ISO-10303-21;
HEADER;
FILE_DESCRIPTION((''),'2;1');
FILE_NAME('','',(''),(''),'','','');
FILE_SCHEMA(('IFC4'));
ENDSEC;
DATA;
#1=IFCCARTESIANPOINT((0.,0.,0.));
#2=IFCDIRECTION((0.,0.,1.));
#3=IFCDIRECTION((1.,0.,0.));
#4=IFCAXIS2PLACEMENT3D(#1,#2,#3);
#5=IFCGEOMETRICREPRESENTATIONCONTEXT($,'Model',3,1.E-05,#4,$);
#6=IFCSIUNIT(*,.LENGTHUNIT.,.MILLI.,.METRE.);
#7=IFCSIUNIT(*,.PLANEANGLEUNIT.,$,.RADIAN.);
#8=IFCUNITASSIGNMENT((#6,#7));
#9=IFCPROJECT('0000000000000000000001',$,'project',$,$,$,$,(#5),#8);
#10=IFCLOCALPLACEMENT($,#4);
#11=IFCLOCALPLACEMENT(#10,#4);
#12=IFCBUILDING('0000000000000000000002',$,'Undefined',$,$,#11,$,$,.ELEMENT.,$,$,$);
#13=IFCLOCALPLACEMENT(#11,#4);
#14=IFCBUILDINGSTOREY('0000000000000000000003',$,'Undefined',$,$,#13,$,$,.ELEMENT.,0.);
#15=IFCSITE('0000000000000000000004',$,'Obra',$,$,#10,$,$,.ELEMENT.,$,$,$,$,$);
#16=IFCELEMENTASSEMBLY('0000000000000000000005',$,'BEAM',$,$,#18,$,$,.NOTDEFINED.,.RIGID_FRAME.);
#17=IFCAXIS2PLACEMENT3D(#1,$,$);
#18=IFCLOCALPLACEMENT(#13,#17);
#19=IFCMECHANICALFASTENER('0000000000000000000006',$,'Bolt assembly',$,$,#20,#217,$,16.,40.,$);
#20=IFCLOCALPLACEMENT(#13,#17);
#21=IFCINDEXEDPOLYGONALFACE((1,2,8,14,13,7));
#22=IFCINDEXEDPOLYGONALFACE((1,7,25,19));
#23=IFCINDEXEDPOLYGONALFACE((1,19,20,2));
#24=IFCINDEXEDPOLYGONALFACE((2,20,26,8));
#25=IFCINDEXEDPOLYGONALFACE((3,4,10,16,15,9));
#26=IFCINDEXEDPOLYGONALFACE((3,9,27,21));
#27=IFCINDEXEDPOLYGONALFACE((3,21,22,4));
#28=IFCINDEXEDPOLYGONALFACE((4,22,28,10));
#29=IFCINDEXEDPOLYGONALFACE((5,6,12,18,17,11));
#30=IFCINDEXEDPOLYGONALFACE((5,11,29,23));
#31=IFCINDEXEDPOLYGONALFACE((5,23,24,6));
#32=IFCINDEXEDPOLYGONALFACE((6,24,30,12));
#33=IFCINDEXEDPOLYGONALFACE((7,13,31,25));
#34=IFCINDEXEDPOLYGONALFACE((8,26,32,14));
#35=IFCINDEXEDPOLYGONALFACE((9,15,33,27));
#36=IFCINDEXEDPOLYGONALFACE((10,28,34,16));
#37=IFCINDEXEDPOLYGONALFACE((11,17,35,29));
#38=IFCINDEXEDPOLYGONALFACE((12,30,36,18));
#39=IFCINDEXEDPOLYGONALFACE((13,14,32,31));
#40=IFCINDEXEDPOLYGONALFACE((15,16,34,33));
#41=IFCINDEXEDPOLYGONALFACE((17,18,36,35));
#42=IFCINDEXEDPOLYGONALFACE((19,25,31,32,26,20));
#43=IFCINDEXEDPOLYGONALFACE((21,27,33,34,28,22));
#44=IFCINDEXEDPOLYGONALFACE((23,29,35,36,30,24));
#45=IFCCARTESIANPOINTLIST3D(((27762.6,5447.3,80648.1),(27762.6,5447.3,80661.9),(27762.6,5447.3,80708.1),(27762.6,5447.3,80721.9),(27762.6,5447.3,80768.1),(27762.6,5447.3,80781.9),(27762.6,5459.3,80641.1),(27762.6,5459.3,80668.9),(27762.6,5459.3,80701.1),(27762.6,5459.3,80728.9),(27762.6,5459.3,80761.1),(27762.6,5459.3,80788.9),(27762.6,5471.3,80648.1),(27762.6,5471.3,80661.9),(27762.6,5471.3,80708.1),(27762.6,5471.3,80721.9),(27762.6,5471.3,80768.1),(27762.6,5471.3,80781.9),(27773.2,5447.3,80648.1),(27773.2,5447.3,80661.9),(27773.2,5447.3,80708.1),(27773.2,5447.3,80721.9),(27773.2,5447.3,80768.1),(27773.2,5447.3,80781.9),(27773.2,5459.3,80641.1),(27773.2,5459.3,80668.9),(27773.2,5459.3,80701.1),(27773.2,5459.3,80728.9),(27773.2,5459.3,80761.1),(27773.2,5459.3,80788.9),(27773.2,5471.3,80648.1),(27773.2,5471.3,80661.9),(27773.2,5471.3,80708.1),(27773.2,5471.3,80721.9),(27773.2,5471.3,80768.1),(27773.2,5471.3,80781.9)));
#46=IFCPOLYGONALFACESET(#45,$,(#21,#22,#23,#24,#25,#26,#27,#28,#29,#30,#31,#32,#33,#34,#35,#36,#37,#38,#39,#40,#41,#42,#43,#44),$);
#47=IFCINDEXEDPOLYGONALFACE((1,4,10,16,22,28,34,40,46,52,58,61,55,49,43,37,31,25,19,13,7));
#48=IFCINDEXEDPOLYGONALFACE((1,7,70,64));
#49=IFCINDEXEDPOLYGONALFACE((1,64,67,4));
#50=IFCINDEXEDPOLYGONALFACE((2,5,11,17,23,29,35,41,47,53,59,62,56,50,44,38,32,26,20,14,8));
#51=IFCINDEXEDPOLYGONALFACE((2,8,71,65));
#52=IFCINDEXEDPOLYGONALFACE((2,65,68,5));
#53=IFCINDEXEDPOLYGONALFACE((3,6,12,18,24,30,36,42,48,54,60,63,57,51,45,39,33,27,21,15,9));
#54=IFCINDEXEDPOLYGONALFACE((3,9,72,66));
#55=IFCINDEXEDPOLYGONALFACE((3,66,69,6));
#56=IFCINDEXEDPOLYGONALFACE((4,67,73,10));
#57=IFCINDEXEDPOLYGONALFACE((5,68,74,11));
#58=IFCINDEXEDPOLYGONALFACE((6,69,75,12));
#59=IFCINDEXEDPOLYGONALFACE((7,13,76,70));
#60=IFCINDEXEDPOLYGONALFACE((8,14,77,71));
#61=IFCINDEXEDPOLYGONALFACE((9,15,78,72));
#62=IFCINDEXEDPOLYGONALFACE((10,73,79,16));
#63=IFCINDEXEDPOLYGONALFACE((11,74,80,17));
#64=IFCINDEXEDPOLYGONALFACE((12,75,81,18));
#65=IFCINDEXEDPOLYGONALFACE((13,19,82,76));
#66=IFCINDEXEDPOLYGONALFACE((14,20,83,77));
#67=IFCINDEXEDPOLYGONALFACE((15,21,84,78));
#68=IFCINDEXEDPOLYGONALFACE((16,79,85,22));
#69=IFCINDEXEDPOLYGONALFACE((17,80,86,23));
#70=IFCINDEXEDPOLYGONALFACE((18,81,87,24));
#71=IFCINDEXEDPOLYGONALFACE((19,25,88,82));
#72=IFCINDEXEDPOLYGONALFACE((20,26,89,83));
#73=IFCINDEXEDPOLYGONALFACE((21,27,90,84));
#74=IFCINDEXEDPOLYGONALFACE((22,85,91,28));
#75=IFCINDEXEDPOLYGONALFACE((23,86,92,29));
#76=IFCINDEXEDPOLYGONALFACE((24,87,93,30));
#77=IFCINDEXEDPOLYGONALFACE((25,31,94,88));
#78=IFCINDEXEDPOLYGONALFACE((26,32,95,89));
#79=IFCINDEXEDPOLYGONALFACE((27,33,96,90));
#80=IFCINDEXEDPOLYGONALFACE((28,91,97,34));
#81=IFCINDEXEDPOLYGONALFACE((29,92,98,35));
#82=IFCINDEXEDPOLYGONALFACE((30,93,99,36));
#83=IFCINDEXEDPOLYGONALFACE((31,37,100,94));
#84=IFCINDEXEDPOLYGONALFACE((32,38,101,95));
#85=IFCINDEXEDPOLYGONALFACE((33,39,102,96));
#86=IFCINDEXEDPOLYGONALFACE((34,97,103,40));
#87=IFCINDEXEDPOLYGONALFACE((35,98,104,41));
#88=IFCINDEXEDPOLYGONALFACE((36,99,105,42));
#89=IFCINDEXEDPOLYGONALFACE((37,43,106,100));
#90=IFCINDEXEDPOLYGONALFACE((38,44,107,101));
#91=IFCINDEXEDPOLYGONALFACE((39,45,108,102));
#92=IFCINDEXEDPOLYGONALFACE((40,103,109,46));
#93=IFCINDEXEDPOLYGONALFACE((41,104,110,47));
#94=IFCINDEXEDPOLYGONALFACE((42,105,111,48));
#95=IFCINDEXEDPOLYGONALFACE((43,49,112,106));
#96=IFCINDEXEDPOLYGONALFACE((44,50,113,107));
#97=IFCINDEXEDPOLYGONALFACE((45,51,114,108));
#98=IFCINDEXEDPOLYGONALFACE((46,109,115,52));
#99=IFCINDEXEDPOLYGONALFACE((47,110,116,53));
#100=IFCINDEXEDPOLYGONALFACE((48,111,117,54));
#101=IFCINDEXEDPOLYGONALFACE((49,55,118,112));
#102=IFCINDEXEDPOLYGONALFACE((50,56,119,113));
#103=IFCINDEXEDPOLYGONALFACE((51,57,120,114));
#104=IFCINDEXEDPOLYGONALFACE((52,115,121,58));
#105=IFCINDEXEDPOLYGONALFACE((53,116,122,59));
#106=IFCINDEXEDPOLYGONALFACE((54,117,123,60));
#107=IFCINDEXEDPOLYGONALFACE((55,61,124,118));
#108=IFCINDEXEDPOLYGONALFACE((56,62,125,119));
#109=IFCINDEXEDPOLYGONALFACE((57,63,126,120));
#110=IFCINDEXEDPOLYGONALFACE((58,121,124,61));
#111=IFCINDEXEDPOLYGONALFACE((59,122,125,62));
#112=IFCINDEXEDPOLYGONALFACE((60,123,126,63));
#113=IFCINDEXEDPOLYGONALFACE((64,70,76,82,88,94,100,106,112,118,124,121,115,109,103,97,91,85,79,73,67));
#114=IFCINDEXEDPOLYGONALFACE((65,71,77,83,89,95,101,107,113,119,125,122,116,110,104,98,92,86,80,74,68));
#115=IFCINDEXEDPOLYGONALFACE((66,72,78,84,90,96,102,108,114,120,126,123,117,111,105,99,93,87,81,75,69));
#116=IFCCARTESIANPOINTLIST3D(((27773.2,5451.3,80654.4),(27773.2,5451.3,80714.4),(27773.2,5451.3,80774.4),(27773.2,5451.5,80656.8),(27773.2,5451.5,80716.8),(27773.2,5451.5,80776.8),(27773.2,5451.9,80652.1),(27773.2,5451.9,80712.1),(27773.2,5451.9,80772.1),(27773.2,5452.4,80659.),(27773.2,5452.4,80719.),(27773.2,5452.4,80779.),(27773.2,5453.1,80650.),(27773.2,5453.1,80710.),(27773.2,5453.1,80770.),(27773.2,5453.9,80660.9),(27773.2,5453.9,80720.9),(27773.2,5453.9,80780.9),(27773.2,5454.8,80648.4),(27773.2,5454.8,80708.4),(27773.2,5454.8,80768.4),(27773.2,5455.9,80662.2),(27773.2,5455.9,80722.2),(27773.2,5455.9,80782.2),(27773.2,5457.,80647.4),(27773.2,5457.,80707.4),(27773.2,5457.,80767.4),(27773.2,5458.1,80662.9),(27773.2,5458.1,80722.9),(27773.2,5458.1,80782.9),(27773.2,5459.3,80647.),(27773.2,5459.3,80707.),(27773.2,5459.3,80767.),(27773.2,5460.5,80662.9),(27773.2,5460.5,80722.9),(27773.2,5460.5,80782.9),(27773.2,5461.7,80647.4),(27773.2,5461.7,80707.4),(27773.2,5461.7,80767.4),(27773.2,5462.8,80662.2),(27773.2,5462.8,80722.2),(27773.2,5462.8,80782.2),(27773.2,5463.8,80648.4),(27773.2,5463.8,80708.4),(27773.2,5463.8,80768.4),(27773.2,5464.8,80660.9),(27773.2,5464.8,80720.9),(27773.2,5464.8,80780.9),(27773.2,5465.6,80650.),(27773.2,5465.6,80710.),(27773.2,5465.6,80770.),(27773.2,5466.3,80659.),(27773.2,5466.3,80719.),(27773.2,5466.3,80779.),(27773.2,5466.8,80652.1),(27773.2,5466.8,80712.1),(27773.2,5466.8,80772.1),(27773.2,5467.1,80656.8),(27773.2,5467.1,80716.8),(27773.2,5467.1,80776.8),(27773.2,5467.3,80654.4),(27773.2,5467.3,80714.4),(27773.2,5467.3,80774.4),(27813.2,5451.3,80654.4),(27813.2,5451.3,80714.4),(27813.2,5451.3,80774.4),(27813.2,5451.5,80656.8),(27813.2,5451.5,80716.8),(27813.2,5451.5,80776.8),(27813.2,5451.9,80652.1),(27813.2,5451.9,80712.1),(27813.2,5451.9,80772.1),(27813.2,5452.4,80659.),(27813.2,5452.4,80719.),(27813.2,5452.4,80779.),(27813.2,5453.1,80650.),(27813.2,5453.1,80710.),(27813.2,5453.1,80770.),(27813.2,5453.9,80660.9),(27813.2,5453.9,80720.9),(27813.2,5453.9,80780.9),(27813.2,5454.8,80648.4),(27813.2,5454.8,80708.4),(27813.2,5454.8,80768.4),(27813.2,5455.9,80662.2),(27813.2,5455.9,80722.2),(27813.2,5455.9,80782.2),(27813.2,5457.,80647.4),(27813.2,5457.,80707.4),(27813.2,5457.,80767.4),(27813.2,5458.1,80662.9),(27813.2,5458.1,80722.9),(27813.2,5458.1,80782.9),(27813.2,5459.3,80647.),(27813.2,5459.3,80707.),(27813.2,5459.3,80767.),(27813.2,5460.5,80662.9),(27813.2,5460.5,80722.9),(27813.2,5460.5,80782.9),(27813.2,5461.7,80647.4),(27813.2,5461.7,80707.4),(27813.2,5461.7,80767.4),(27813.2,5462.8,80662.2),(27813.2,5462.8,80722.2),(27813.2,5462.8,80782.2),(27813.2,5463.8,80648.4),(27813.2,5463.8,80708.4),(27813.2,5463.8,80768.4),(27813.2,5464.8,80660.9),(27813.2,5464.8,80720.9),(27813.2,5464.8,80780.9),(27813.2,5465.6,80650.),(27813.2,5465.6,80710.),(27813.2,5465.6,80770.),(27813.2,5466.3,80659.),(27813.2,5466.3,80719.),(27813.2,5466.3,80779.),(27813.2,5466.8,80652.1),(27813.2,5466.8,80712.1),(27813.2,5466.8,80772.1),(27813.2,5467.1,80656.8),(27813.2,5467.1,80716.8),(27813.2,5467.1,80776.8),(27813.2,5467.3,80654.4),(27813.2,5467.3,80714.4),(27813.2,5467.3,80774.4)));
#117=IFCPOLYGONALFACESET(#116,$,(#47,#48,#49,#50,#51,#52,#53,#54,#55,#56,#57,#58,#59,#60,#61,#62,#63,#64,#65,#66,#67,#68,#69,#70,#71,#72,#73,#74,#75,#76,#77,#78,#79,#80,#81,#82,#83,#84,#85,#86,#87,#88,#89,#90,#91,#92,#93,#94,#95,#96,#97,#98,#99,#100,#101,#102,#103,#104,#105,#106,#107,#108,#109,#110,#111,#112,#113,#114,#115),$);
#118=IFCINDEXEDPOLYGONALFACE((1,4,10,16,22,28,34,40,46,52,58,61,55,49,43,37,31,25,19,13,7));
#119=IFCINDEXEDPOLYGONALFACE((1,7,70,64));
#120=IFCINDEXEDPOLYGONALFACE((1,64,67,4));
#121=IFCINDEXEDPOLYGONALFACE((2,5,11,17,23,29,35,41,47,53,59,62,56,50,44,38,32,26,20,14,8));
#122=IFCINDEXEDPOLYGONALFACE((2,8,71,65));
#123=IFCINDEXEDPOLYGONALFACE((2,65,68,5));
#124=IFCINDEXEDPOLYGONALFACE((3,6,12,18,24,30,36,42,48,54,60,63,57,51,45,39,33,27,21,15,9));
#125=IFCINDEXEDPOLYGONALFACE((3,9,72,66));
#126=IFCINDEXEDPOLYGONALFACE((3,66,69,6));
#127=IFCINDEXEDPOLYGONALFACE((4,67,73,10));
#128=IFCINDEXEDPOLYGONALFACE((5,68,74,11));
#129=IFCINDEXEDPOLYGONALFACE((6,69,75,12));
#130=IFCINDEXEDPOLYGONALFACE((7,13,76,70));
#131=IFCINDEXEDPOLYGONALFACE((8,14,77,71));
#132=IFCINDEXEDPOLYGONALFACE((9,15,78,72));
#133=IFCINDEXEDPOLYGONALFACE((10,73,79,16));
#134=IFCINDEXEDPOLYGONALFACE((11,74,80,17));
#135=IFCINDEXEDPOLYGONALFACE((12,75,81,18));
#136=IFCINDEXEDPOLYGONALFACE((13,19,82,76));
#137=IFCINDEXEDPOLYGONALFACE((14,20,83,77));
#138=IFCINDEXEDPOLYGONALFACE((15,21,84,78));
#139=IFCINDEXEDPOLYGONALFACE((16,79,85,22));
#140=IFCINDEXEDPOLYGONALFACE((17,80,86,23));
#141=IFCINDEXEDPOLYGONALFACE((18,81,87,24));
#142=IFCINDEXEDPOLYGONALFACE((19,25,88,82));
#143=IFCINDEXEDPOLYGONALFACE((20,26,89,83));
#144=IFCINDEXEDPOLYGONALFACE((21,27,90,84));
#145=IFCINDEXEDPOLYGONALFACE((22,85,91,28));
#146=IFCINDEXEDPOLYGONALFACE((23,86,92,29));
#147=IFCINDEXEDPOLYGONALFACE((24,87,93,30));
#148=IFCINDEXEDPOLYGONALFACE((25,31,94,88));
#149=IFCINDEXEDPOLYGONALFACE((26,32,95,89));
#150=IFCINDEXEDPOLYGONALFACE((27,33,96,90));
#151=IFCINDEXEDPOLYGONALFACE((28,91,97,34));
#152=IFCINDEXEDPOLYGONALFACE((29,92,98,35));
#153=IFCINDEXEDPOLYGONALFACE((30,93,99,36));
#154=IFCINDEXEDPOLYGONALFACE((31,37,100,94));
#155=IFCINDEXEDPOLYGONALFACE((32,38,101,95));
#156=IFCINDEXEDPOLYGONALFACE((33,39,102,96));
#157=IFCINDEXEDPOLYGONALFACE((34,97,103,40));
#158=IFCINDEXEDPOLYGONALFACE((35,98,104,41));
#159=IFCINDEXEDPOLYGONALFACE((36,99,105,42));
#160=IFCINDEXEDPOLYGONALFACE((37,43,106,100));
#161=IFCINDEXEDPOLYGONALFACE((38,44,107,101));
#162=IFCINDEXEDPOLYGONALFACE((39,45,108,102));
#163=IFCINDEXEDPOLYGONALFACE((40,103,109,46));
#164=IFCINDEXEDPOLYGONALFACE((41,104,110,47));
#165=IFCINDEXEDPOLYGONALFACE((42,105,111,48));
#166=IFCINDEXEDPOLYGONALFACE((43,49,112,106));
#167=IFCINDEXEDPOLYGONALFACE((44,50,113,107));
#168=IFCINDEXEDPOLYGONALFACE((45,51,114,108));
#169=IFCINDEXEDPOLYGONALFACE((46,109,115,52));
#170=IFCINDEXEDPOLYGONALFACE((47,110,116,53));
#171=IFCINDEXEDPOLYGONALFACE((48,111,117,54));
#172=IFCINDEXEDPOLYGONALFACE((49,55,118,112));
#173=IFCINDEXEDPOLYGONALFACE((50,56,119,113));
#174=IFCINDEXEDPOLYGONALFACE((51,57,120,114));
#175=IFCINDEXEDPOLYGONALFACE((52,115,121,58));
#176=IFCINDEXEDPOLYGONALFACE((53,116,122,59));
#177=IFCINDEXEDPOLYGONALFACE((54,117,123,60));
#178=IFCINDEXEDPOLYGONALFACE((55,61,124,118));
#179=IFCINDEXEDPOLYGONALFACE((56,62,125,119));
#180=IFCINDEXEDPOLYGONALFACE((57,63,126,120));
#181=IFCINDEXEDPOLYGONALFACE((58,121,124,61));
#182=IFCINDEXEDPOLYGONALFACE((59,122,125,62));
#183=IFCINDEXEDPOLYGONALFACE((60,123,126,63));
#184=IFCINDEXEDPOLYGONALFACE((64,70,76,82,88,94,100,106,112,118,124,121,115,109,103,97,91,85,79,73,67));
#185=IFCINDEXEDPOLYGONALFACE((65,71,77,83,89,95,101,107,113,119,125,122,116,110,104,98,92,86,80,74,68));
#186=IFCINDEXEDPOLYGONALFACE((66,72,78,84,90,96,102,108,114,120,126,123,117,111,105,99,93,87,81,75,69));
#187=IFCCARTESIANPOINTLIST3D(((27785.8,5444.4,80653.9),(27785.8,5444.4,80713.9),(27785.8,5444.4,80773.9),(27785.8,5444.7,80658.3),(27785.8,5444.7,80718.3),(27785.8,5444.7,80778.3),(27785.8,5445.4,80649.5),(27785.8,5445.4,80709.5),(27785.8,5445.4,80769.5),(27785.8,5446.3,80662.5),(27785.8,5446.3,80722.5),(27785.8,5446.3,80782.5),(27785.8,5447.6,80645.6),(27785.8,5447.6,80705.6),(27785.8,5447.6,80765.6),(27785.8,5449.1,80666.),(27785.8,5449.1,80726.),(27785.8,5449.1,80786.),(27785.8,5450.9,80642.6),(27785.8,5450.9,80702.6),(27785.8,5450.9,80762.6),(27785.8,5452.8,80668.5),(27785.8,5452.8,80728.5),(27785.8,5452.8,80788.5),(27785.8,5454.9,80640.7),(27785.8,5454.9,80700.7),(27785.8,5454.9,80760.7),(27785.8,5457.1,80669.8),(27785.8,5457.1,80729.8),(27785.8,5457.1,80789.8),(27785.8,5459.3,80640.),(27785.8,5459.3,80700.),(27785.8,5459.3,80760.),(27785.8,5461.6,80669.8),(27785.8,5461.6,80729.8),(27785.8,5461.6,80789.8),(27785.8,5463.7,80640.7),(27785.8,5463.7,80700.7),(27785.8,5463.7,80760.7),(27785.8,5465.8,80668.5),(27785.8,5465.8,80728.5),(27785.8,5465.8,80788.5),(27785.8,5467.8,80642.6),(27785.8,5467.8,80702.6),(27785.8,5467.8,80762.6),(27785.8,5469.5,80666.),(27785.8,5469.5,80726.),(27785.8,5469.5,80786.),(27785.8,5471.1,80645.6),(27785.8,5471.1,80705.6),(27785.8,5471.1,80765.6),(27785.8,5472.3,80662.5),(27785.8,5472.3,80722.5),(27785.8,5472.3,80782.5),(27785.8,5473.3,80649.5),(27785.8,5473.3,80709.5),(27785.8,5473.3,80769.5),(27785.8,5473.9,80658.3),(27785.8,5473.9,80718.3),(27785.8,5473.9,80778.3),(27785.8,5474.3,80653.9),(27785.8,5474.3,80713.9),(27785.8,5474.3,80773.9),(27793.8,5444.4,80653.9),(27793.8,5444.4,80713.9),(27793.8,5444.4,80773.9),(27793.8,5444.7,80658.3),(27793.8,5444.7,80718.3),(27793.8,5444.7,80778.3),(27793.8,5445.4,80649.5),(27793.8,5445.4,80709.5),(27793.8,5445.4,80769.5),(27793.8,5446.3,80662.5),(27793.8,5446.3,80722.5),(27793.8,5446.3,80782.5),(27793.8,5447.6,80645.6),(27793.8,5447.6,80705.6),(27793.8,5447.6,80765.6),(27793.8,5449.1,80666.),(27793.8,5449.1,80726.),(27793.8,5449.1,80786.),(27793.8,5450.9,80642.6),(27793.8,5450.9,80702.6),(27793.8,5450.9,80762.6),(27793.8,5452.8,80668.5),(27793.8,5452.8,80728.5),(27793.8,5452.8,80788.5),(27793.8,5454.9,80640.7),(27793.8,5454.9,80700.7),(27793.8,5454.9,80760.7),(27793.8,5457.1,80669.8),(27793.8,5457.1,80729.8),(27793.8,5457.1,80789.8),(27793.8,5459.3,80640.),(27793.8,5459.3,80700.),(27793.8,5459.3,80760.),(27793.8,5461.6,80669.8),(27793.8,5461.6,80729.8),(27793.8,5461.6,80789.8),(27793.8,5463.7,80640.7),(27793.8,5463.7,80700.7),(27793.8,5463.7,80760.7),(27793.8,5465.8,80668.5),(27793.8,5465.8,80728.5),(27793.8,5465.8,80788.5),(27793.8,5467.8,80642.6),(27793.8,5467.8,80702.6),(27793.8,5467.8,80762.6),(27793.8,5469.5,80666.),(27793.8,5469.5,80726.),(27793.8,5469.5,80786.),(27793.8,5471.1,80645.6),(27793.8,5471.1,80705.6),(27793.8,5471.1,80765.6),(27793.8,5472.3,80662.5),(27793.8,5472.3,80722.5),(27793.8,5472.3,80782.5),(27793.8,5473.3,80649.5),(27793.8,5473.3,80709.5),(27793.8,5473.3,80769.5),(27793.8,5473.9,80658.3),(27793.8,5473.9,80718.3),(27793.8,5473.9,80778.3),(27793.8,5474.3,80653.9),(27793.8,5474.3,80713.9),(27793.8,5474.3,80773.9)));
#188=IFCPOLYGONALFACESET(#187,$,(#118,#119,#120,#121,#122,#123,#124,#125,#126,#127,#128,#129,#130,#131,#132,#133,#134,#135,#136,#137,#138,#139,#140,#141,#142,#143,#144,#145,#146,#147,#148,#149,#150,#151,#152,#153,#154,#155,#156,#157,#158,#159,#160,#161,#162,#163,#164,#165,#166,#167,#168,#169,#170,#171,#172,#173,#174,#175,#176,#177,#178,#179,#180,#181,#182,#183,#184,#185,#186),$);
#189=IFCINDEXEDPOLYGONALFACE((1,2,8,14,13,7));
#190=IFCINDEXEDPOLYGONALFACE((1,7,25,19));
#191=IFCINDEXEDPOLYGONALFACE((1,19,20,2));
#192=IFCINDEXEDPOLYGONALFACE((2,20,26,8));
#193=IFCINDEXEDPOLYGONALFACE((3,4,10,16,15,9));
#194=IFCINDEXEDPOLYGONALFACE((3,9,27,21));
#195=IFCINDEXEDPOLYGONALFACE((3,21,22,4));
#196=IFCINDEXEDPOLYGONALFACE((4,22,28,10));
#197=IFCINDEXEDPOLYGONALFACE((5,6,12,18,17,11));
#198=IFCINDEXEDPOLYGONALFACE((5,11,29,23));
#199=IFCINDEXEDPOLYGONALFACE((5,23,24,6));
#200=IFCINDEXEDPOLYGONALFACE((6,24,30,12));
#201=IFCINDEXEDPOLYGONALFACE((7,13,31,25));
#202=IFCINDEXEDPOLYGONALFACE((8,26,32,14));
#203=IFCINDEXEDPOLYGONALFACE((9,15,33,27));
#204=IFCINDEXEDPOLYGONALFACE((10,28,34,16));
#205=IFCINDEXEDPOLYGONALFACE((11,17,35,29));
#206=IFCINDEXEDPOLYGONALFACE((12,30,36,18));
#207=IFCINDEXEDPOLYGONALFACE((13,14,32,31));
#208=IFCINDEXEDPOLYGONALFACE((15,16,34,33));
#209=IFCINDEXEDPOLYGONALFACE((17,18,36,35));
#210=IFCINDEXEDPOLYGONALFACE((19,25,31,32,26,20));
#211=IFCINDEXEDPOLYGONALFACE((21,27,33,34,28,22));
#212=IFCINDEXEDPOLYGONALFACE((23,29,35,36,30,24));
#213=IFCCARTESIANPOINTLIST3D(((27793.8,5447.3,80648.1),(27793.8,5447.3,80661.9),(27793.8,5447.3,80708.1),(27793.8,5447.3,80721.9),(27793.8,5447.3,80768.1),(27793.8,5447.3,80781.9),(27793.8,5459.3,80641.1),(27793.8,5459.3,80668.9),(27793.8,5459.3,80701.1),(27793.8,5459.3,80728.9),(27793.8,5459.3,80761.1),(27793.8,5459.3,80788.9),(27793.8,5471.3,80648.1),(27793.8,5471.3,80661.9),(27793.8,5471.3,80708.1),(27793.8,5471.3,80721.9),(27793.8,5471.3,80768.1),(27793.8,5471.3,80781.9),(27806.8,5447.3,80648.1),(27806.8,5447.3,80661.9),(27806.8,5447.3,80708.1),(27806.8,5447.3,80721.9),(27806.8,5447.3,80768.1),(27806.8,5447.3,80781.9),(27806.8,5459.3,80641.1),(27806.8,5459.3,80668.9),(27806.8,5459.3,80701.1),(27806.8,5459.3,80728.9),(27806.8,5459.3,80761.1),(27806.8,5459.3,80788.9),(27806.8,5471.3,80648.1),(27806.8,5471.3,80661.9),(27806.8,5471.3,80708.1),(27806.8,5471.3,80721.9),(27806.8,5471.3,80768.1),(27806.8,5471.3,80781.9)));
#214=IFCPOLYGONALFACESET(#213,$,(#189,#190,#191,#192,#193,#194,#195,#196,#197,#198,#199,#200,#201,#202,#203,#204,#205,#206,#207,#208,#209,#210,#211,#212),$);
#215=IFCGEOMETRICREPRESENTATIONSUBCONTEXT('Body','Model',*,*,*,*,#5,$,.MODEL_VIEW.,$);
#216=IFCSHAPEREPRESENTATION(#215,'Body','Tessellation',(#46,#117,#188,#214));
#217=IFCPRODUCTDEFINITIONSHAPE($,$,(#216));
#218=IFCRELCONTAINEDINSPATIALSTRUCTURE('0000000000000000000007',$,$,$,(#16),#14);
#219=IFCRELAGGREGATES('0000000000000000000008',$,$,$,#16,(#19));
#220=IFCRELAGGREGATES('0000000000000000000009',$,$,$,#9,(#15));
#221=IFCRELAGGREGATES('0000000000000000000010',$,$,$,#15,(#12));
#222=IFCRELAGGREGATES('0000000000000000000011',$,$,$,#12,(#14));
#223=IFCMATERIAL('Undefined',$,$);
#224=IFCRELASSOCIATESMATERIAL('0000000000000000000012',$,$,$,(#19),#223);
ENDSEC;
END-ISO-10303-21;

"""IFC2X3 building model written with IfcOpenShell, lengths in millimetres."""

from ifc_helpers import new_model, si_unit, frame, origin_with_axes, origin_2d_with_axis, place, context, subcontext, project, spatial, polyline, circle, outline, extrude, source, transform, mapped, material, element, aggregate, save


model = new_model("IFC2X3")

# Units and contexts
model_context = context("Model", 3, precision=1e-05, world=origin_with_axes())
body_context = subcontext(model_context, "Body", "Model", "MODEL_VIEW")
ifc_project = project(units=[si_unit("LENGTHUNIT", "METRE", prefix="MILLI"), si_unit("PLANEANGLEUNIT", "RADIAN")], contexts=[model_context])

# Site, building, storey
site_placement = place(None, origin_with_axes())
site = spatial("IfcSite", under=ifc_project, at=site_placement, Name="Obra", CompositionType="ELEMENT")
building_placement = place(site_placement, origin_with_axes())
building = spatial("IfcBuilding", under=site, at=building_placement, Name="Undefined", CompositionType="ELEMENT")
storey_placement = place(building_placement, origin_with_axes())
storey = spatial("IfcBuildingStorey", under=building, at=storey_placement, Name="Undefined", CompositionType="ELEMENT", Elevation=0.0)

# Shared definitions
ifc_material_1 = material(Name="Undefined")

# Element assembly, mechanical fastener
assembly_1_placement = place(storey_placement, origin_with_axes())
assembly_1 = element("IfcElementAssembly", 1, at=assembly_1_placement, inside=storey, Name="BEAM", AssemblyPlace="NOTDEFINED", PredefinedType="RIGID_FRAME")
shared_shape_1 = source(origin_with_axes(), body_context, "Body", "SweptSolid", [
    extrude(outline(polyline([(13.9, 0.0), (6.9, 12.0), (-6.9, 12.0), (-13.9, 0.0), (-6.9, -12.0), (6.9, -12.0), (13.9, 0.0)])), frame((0.0, -19.9, 0.0), z_axis=(0.0, 1.0, 0.0), x_axis=(1.0, 0.0, 0.0)), (0.0, 0.0, 1.0), 10.6),
    extrude(circle(Radius=8.0, at=origin_2d_with_axis()), frame((0.0, -9.3, 0.0), z_axis=(0.0, 1.0, 0.0), x_axis=(1.0, 0.0, 0.0)), (0.0, 0.0, 1.0), 40.0),
    extrude(circle(Radius=15.0, at=origin_2d_with_axis()), frame((0.0, 3.3, 0.0), z_axis=(0.0, 1.0, 0.0), x_axis=(1.0, 0.0, 0.0)), (0.0, 0.0, 1.0), 8.0),
    extrude(outline(polyline([(13.9, 0.0), (6.9, 12.0), (-6.9, 12.0), (-13.9, 0.0), (-6.9, -12.0), (6.9, -12.0), (13.9, 0.0)])), frame((0.0, 11.3, 0.0), z_axis=(0.0, 1.0, 0.0), x_axis=(1.0, 0.0, 0.0)), (0.0, 0.0, 1.0), 13.0),
])
mechanical_fastener_1_placement = place(assembly_1_placement, frame((27782.5, 5509.3, 80850.0), z_axis=(0.000001, -1.0, 0.0), x_axis=(0.0, 0.0, -1.0)))
mechanical_fastener_1 = element("IfcMechanicalFastener", 2, at=mechanical_fastener_1_placement, material=ifc_material_1, Name="Bolt assembly", NominalDiameter=16.0, NominalLength=40.0, context=body_context, shape_type="MappedRepresentation", body=[
    mapped(shared_shape_1, transform((75.0, 0.0, 50.0))),
    mapped(shared_shape_1, transform((135.0, 0.0, 50.0))),
    mapped(shared_shape_1, transform((195.0, 0.0, 50.0))),
])
aggregate(assembly_1, [mechanical_fastener_1])

save(model, "model.ifc")
